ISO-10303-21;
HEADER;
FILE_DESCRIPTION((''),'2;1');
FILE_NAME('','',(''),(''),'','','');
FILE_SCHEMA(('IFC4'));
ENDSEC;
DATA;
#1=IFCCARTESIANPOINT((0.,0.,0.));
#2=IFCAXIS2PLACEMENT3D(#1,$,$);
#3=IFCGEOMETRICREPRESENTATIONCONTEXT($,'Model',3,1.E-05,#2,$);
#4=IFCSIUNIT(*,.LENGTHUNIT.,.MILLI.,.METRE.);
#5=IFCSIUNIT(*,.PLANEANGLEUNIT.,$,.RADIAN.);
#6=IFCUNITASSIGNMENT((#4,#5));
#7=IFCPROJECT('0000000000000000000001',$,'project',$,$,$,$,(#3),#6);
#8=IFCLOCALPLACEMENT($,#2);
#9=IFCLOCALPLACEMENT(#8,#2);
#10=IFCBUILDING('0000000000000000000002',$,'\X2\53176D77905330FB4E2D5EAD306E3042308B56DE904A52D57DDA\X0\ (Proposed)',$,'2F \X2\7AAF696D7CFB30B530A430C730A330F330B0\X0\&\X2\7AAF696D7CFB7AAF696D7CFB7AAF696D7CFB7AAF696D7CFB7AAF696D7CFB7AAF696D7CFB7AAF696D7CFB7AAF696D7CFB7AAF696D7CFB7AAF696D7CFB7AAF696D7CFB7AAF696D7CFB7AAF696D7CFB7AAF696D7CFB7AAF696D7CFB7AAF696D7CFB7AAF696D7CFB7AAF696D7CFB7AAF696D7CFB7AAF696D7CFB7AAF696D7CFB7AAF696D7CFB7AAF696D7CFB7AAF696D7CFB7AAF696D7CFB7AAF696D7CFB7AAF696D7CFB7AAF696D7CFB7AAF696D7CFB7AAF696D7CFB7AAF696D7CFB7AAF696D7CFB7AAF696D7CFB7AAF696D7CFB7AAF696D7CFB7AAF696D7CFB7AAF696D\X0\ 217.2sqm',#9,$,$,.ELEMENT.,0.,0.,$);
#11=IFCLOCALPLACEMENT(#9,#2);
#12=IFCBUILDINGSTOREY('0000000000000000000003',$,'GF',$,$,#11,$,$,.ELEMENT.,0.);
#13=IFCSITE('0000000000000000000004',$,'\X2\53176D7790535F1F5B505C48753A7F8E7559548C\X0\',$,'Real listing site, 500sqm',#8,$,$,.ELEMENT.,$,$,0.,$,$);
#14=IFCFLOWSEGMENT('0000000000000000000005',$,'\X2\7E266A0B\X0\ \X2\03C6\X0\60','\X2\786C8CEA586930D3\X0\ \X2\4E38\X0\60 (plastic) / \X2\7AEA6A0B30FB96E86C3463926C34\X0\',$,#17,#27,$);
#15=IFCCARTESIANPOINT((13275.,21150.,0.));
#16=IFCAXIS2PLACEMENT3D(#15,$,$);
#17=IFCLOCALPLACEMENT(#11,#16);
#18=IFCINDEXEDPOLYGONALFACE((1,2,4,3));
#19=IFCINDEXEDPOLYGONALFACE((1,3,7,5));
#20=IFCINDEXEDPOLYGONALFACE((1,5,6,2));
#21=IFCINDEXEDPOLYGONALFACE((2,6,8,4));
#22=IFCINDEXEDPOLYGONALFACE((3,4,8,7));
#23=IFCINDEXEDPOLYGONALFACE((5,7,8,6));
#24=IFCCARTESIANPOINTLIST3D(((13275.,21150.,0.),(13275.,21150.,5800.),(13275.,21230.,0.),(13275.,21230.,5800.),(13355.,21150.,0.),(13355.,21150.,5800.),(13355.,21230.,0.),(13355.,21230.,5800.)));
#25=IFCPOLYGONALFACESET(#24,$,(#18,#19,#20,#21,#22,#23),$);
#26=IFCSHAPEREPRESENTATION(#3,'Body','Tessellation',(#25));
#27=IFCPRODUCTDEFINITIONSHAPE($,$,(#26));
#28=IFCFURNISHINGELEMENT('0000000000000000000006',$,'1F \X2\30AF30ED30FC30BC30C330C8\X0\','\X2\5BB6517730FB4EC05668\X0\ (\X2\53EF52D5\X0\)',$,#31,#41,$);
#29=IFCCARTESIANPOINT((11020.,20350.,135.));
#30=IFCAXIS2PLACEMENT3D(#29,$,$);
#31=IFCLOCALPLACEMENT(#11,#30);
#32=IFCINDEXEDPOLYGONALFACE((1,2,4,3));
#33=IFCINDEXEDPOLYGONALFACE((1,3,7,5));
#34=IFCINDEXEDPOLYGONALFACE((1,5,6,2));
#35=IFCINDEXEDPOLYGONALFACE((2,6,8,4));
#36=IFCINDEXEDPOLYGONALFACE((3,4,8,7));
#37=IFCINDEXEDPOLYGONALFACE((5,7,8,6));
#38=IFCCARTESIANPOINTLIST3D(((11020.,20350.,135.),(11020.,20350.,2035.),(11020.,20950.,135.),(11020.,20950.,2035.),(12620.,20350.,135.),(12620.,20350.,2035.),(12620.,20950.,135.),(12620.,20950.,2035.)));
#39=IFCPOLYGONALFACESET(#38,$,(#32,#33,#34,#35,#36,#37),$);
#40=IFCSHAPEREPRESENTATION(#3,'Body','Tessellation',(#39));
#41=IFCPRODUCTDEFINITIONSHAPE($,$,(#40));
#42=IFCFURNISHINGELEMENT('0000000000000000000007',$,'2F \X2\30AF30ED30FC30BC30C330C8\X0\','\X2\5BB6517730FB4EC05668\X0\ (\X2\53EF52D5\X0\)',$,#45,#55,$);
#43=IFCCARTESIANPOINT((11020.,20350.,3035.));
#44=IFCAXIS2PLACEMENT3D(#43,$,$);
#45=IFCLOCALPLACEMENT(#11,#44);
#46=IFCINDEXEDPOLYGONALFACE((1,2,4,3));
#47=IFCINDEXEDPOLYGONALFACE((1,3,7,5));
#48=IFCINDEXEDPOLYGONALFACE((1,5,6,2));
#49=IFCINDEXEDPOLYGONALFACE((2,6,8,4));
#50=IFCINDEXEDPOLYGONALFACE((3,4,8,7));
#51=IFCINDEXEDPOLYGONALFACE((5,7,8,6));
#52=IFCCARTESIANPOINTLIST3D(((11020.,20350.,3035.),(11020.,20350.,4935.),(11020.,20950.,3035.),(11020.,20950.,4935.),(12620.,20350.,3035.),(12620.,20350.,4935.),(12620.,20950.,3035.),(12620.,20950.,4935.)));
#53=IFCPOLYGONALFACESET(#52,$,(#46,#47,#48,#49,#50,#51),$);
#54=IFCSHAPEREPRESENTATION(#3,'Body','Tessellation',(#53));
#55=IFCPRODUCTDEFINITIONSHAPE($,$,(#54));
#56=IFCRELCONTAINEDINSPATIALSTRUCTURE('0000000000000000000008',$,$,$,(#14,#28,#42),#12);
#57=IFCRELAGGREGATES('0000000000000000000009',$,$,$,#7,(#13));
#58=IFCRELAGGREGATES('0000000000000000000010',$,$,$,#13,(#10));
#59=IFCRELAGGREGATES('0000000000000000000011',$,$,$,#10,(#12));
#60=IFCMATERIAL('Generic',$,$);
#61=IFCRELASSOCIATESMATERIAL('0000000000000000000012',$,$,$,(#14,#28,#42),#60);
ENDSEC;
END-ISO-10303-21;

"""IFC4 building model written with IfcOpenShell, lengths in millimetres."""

from ifc_helpers import new_model, si_unit, frame, frame_2d, origin, place, context, project, spatial, rectangle, extrude, material, element, save


model = new_model("IFC4")

# Units and contexts
model_context = context("Model", 3, precision=1e-05, world=origin())
ifc_project = project(units=[si_unit("LENGTHUNIT", "METRE", prefix="MILLI"), si_unit("PLANEANGLEUNIT", "RADIAN")], contexts=[model_context])

# Site, building, storey
site_placement = place(None, origin())
site = spatial("IfcSite", under=ifc_project, at=site_placement, Name="北海道弟子屈町美留和", ObjectType="Real listing site, 500sqm", CompositionType="ELEMENT", RefElevation=0.0)
building_placement = place(site_placement, origin())
building = spatial("IfcBuilding", under=site, at=building_placement, Name="北海道・中庭のある回遊動線 (Proposed)", ObjectType="2F 窯業系サイディング&窯業系窯業系窯業系窯業系窯業系窯業系窯業系窯業系窯業系窯業系窯業系窯業系窯業系窯業系窯業系窯業系窯業系窯業系窯業系窯業系窯業系窯業系窯業系窯業系窯業系窯業系窯業系窯業系窯業系窯業系窯業系窯業系窯業系窯業系窯業系窯業系窯業 217.2sqm", CompositionType="ELEMENT", ElevationOfRefHeight=0.0, ElevationOfTerrain=0.0)
storey_placement = place(building_placement, origin())
storey = spatial("IfcBuildingStorey", under=building, at=storey_placement, Name="GF", CompositionType="ELEMENT", Elevation=0.0)

# Shared definitions
ifc_material_1 = material(Name="Generic")

# Flow segment
flow_segment_placement = place(storey_placement, frame((13275.0, 21150.0, 0.0)))
element("IfcFlowSegment", 1, at=flow_segment_placement, inside=storey, material=ifc_material_1, Name="縦樋 φ60", Description="硬質塩ビ 丸60 (plastic) / 竪樋・雨水排水", context=model_context, shape_type="SweptSolid", body=[
    extrude(rectangle(XDim=80.0, YDim=80.0, at=frame_2d((40.0, 40.0))), frame((13275.0, 21150.0, 0.0)), (0.0, 0.0, 1.0), 5800.0),
])

# Furnishing elements
furnishing_1_placement = place(storey_placement, frame((11020.0, 20350.0, 135.0)))
element("IfcFurnishingElement", 2, at=furnishing_1_placement, inside=storey, material=ifc_material_1, Name="1F クローゼット", Description="家具・什器 (可動)", context=model_context, shape_type="SweptSolid", body=[
    extrude(rectangle(XDim=1600.0, YDim=600.0, at=frame_2d((800.0, 300.0))), frame((11020.0, 20350.0, 135.0)), (0.0, 0.0, 1.0), 1900.0),
])
furnishing_2_placement = place(storey_placement, frame((11020.0, 20350.0, 3035.0)))
element("IfcFurnishingElement", 3, at=furnishing_2_placement, inside=storey, material=ifc_material_1, Name="2F クローゼット", Description="家具・什器 (可動)", context=model_context, shape_type="SweptSolid", body=[
    extrude(rectangle(XDim=1600.0, YDim=600.0, at=frame_2d((800.0, 300.0))), frame((11020.0, 20350.0, 3035.0)), (0.0, 0.0, 1.0), 1900.0),
])

save(model, "model.ifc")
